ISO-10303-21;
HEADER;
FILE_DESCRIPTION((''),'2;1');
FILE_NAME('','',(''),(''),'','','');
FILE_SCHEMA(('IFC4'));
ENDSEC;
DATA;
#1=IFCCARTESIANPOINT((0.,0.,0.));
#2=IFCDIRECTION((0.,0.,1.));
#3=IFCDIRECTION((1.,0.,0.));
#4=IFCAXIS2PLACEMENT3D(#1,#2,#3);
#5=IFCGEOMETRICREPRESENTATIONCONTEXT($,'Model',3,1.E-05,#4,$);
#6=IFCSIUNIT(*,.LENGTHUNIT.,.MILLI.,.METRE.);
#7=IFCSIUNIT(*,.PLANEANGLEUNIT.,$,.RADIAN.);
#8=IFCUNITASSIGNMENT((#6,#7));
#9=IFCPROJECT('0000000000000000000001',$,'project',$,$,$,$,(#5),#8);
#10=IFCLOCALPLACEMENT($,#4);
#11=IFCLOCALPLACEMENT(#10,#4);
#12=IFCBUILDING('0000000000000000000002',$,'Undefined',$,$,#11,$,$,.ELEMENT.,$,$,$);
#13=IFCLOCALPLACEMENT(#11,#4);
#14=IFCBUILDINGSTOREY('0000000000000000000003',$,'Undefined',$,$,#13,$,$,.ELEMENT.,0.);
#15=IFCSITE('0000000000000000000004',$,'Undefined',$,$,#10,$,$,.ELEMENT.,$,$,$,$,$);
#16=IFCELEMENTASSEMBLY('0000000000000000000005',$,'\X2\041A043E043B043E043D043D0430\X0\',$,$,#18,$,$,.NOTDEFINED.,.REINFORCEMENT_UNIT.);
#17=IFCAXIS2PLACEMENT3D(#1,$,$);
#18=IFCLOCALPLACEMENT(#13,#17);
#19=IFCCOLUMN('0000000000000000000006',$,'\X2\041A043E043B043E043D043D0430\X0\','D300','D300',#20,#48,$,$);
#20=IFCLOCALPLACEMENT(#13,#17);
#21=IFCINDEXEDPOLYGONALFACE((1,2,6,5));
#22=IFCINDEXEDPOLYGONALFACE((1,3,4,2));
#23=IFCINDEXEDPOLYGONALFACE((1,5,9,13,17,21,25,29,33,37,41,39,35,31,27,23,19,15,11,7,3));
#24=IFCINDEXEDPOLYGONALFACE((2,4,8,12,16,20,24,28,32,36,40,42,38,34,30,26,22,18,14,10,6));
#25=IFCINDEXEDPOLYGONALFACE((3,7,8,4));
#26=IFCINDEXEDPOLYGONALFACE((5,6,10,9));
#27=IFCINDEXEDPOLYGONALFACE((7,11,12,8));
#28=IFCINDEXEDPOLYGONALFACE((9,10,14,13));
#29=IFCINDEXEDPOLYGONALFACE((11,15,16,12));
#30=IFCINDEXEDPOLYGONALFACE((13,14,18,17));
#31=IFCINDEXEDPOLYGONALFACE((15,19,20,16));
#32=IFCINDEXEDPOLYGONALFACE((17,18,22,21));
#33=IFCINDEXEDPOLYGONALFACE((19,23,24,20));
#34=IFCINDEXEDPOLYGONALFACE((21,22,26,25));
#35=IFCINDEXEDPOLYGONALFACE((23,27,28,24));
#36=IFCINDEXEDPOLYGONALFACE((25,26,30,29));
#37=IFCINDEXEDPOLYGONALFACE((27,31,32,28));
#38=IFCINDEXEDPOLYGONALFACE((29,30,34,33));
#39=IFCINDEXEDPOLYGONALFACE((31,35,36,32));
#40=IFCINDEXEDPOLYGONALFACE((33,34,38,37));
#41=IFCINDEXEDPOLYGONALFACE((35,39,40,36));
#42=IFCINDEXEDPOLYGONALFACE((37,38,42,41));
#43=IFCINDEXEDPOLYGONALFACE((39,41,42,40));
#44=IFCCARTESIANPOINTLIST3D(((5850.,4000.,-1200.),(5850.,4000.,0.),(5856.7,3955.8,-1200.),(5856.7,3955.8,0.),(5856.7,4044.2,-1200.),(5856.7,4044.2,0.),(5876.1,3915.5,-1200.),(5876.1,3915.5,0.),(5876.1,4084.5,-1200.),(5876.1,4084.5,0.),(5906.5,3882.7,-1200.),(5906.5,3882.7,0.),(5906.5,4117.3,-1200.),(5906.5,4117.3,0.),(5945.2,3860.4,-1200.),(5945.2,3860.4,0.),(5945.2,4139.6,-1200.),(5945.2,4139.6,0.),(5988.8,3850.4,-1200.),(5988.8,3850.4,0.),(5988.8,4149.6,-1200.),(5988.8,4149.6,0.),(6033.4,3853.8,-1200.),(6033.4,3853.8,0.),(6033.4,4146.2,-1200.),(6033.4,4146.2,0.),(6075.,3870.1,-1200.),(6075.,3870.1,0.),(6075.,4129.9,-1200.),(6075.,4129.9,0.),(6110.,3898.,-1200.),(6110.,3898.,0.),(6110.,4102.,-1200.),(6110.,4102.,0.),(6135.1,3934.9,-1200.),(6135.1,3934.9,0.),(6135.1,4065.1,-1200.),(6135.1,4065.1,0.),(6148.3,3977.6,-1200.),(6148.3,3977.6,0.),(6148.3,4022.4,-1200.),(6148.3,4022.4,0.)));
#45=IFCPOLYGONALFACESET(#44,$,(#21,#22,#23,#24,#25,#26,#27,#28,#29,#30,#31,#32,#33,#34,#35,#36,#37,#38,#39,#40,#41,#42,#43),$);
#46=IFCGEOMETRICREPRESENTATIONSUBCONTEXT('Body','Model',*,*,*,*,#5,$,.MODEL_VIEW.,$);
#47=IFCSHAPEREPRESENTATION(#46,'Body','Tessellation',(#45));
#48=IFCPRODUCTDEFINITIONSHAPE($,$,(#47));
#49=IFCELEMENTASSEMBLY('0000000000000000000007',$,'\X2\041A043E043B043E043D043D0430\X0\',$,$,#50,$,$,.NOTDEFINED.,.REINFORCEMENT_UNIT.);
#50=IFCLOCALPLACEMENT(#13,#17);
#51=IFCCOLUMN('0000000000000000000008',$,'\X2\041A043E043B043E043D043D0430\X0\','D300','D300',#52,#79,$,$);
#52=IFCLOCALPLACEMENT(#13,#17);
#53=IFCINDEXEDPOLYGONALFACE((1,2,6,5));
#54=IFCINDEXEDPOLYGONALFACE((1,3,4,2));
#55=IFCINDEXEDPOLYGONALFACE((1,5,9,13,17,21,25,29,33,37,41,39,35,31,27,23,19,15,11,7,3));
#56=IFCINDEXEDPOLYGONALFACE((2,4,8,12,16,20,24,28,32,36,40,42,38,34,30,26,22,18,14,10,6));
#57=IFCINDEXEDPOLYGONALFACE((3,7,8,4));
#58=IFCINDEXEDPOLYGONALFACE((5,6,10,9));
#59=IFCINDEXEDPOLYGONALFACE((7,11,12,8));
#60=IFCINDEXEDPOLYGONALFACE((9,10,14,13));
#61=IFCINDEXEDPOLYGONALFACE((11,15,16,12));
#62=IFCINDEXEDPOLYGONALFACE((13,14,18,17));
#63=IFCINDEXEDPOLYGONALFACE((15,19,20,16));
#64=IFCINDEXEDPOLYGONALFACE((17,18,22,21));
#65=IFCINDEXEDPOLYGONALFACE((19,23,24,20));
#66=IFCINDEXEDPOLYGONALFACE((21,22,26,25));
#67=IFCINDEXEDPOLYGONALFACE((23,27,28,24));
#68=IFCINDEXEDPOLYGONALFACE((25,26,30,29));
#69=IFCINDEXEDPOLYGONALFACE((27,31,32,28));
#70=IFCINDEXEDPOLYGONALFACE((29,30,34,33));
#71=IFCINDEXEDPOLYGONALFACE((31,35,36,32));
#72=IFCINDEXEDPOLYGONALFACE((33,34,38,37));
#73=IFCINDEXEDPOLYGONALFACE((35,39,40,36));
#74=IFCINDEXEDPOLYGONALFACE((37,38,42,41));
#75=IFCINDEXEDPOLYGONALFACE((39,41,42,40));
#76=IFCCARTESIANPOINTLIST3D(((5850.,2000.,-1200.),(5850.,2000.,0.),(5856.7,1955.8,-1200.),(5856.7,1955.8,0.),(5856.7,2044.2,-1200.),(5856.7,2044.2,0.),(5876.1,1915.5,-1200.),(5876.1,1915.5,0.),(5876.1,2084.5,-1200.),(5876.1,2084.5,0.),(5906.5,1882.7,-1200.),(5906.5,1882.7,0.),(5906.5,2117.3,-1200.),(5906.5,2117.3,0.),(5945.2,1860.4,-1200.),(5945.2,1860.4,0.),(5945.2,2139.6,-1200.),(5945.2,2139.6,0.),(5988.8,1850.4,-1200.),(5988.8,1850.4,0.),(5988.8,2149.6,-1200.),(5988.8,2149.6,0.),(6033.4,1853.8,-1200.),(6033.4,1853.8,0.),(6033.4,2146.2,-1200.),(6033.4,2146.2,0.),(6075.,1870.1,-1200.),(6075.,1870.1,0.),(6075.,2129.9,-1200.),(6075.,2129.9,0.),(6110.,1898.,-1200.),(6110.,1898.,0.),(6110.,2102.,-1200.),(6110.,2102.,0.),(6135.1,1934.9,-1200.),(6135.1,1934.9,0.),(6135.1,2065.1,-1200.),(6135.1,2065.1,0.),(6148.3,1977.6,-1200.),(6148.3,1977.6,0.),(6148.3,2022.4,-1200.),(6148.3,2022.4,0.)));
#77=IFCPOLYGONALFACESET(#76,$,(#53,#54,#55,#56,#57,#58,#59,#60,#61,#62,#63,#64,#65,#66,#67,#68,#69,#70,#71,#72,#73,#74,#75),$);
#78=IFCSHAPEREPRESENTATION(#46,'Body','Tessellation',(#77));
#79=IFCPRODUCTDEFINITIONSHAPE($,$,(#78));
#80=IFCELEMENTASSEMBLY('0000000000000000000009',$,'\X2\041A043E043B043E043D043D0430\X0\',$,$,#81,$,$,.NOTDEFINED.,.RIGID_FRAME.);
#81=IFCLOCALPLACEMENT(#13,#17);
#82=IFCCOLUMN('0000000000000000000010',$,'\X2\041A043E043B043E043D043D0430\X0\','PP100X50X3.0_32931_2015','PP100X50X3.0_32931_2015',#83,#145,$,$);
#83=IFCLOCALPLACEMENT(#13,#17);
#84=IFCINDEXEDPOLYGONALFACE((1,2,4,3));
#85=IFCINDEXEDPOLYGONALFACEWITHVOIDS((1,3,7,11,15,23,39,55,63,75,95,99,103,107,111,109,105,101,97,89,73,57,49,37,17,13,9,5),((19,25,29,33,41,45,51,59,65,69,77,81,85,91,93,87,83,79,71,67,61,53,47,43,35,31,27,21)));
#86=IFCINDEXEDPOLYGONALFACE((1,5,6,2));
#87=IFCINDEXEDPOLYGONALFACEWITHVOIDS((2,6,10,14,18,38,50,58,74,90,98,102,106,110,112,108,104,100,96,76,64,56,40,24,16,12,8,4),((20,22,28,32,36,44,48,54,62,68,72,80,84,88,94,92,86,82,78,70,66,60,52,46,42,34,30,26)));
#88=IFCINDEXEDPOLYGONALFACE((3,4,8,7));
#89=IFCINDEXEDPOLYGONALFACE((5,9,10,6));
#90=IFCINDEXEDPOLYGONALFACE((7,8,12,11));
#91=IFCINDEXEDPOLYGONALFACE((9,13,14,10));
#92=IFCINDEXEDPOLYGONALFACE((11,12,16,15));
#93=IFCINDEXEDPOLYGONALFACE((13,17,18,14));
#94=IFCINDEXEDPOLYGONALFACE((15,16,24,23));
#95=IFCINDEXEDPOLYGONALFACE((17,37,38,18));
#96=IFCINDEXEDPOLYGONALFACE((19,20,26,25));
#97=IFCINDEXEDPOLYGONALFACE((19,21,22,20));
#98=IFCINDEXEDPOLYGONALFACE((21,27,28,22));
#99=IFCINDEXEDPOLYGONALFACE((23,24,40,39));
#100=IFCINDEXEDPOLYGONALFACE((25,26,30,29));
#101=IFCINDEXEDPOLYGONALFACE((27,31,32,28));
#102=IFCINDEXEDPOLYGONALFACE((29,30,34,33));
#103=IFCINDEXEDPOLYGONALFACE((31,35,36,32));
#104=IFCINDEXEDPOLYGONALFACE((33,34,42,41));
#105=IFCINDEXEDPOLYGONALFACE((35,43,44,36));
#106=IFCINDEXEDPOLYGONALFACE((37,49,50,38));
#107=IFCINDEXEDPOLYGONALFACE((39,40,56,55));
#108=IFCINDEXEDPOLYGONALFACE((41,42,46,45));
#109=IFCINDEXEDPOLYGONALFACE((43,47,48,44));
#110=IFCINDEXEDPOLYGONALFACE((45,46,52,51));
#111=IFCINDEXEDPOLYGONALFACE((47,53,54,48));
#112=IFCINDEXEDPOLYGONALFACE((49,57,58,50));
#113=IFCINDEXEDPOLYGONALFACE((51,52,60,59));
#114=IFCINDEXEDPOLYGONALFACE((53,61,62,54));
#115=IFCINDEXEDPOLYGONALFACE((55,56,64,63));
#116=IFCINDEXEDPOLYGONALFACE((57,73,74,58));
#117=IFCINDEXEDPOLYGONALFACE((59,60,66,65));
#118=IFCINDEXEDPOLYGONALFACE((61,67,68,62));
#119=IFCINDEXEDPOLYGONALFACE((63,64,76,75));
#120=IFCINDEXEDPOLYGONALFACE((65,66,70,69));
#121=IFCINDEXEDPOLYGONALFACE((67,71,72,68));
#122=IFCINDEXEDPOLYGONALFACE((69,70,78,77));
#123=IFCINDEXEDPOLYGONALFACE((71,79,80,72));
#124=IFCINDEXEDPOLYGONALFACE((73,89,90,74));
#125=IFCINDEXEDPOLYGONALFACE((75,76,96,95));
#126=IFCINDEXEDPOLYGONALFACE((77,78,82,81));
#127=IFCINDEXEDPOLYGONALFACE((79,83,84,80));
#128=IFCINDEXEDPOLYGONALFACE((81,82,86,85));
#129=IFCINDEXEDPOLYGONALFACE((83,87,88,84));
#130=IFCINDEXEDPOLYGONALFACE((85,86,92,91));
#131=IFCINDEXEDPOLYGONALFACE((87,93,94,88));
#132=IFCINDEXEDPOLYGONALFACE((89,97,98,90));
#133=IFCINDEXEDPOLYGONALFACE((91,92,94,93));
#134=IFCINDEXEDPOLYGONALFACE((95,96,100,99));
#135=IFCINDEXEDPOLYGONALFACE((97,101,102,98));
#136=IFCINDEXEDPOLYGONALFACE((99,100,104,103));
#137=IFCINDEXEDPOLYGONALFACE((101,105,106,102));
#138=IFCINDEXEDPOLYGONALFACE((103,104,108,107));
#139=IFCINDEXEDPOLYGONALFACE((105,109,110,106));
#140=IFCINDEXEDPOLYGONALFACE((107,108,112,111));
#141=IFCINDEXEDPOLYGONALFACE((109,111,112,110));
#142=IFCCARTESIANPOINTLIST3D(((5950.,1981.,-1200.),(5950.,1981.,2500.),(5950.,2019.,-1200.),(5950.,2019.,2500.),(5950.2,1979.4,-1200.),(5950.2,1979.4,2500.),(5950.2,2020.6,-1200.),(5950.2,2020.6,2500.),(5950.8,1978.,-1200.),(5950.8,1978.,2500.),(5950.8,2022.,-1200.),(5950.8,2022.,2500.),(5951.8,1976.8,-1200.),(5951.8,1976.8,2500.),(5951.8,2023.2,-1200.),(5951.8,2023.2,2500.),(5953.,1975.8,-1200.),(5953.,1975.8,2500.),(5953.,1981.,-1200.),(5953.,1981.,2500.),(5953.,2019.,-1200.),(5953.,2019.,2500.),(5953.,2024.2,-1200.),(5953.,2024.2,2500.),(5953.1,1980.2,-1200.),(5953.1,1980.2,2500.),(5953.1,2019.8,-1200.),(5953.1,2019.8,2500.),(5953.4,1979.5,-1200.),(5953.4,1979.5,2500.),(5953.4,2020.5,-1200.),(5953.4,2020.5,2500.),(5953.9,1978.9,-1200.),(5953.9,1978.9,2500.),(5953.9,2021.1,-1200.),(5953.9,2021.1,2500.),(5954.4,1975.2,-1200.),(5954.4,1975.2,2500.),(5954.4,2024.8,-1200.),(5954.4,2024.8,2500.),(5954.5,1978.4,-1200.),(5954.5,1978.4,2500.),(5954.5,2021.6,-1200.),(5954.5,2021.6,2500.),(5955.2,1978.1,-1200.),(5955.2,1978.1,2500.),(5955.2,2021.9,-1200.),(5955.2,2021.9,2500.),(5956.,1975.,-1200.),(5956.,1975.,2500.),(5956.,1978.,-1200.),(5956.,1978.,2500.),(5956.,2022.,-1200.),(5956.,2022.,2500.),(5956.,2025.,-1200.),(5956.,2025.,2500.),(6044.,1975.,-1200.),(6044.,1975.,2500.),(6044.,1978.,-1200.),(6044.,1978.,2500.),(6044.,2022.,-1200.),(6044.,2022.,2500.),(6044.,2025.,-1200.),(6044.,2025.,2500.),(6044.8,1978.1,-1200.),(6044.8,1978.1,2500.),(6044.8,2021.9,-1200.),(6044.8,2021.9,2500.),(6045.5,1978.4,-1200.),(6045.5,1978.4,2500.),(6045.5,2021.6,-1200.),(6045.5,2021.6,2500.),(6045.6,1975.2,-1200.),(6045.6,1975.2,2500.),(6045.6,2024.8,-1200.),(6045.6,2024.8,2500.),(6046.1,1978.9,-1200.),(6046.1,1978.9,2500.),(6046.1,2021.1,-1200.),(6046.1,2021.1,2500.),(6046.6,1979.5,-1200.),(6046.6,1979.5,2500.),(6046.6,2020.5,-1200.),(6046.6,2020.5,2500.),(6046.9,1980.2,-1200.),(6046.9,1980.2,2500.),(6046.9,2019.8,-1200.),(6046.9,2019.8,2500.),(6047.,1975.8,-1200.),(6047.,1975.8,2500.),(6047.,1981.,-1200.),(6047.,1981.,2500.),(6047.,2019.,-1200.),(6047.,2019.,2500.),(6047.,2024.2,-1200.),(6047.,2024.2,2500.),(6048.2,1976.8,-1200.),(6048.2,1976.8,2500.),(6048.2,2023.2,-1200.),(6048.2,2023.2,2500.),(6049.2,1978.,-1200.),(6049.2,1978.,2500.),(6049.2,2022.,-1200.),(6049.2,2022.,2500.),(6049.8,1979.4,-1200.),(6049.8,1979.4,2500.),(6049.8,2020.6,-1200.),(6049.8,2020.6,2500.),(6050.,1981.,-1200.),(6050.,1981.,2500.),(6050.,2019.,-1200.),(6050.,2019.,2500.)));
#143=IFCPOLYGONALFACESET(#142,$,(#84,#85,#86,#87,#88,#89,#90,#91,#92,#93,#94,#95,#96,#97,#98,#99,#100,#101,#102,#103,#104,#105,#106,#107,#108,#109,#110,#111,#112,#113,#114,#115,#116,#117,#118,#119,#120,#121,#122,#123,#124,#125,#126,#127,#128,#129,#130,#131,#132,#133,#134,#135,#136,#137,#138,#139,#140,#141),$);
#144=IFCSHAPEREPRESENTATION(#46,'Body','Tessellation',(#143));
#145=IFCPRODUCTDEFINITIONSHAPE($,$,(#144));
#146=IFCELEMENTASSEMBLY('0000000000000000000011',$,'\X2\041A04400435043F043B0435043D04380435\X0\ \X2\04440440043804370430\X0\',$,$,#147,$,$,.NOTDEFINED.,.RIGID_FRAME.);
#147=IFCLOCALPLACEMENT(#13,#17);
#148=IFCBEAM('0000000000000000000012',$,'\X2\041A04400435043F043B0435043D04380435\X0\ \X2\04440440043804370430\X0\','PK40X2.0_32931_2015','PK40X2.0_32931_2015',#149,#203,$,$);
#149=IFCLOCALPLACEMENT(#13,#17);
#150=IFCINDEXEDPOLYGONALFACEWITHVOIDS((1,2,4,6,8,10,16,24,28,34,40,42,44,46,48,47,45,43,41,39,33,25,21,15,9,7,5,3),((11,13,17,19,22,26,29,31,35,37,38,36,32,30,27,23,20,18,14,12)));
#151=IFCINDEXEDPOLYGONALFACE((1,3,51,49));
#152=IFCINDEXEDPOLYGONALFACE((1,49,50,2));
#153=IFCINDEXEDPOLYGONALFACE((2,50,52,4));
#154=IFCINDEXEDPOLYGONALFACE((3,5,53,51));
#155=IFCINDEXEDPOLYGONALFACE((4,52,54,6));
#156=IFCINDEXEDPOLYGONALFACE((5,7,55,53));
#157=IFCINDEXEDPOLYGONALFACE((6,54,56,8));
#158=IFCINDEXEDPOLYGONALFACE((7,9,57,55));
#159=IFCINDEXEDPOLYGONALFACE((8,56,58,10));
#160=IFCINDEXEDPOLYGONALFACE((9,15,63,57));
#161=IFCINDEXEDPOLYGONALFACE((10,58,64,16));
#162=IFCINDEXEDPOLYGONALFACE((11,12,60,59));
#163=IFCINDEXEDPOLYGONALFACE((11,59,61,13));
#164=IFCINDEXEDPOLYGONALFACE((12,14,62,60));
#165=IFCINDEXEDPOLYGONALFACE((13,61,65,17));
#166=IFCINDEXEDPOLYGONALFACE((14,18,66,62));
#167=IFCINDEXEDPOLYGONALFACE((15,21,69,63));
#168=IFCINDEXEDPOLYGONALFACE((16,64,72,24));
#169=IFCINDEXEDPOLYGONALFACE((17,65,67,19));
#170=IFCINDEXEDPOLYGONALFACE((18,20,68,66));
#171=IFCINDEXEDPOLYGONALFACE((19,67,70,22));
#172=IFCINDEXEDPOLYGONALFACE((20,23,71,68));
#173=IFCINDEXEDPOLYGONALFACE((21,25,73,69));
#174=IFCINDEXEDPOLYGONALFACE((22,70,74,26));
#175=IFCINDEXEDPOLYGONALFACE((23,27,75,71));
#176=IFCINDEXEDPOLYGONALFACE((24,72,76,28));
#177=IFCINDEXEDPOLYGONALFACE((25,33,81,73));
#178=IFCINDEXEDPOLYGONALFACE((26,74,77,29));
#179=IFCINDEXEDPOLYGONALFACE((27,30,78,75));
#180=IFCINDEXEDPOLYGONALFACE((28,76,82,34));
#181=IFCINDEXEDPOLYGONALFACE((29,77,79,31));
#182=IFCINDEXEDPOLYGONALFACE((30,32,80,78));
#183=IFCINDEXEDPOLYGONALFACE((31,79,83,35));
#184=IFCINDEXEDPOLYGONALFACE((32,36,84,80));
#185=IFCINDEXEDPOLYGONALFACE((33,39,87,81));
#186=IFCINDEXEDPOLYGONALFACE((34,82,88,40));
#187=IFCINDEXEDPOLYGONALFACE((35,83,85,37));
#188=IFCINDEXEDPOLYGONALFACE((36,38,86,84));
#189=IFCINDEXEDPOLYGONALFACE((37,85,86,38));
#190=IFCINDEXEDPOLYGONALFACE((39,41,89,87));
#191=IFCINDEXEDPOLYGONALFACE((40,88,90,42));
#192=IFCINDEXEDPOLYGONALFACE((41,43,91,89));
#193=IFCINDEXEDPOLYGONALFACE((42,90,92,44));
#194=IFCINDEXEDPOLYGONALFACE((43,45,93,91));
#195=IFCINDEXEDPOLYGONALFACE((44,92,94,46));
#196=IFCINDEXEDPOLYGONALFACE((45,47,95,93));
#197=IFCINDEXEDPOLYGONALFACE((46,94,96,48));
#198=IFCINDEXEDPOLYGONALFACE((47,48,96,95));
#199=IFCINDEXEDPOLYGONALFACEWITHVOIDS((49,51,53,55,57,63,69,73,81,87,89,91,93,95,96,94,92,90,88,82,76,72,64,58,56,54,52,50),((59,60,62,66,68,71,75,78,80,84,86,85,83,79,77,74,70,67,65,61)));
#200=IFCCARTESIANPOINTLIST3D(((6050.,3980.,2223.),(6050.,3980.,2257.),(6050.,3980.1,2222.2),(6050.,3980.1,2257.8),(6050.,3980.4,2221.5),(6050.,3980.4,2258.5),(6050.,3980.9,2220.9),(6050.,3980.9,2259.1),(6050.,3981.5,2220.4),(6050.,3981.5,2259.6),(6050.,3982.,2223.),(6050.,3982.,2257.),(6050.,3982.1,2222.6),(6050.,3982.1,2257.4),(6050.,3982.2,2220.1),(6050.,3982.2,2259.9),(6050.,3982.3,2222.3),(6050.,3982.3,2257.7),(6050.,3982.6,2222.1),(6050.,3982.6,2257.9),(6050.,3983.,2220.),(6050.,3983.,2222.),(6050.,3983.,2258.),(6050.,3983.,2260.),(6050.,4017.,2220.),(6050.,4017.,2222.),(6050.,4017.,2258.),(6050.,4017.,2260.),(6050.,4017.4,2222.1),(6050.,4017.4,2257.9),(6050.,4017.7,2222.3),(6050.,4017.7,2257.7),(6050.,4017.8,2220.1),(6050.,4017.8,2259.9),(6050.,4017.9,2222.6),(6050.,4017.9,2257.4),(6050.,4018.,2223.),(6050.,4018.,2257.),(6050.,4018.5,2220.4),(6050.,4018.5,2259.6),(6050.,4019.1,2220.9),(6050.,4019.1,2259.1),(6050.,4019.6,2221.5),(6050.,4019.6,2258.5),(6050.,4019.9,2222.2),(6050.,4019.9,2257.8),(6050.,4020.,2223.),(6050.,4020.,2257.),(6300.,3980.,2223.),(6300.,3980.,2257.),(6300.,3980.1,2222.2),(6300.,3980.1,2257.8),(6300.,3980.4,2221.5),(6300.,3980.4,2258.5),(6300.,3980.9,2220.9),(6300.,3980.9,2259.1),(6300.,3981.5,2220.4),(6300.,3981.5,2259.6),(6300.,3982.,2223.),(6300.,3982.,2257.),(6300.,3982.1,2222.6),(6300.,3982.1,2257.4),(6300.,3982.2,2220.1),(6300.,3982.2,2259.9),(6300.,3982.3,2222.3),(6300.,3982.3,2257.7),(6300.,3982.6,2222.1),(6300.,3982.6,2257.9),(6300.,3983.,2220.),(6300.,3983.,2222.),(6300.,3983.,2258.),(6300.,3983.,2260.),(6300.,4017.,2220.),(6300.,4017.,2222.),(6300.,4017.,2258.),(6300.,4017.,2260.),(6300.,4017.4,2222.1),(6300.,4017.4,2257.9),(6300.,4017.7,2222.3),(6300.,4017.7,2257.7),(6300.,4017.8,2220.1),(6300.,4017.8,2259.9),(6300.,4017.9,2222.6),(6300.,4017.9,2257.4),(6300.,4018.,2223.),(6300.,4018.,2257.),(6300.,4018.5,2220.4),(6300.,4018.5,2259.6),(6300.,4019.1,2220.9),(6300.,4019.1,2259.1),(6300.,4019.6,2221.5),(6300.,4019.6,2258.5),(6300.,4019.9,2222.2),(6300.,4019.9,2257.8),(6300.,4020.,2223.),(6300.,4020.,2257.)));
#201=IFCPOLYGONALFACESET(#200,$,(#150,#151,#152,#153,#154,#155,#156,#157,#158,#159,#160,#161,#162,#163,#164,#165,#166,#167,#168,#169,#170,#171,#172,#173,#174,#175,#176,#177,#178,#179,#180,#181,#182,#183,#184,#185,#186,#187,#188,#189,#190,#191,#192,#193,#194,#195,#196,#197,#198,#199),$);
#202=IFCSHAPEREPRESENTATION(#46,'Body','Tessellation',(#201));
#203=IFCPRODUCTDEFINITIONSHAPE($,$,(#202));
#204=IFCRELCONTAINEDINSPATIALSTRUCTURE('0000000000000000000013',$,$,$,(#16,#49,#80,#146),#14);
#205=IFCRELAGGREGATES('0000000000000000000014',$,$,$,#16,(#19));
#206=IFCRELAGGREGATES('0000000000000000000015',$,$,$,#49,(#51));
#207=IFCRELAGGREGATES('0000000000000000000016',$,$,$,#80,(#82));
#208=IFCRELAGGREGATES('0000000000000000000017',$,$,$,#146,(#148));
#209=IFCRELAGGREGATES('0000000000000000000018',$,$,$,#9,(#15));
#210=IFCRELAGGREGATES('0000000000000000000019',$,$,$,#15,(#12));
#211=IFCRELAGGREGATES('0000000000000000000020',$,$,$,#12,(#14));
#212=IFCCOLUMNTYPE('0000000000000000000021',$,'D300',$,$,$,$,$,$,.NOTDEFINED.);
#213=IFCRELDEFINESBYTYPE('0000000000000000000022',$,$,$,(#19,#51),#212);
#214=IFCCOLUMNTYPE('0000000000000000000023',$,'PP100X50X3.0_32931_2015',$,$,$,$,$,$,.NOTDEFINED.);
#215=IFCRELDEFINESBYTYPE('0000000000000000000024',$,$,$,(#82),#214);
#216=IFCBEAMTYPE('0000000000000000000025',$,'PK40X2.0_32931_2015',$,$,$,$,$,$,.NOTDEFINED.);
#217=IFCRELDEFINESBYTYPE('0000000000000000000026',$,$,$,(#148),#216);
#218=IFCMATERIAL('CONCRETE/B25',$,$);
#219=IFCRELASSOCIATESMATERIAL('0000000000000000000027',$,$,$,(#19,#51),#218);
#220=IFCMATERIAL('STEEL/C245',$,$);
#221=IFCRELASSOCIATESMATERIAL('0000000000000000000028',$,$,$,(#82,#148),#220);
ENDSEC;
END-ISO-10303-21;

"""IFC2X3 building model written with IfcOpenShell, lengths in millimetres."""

from ifc_helpers import new_model, si_unit, frame, origin_with_axes, origin_2d_with_axis, place, context, subcontext, project, spatial, hollow_rectangle, circle, extrude, material, type_object, element, aggregate, save


model = new_model("IFC2X3")

# Units and contexts
model_context = context("Model", 3, precision=1e-05, world=origin_with_axes())
body_context = subcontext(model_context, "Body", "Model", "MODEL_VIEW")
ifc_project = project(units=[si_unit("LENGTHUNIT", "METRE", prefix="MILLI"), si_unit("PLANEANGLEUNIT", "RADIAN")], contexts=[model_context])

# Site, building, storey
site_placement = place(None, origin_with_axes())
site = spatial("IfcSite", under=ifc_project, at=site_placement, Name="Undefined", CompositionType="ELEMENT")
building_placement = place(site_placement, origin_with_axes())
building = spatial("IfcBuilding", under=site, at=building_placement, Name="Undefined", CompositionType="ELEMENT")
storey_placement = place(building_placement, origin_with_axes())
storey = spatial("IfcBuildingStorey", under=building, at=storey_placement, Name="Undefined", CompositionType="ELEMENT", Elevation=0.0)

# Element assemblies, columns
assembly_1_placement = place(storey_placement, origin_with_axes())
assembly_1 = element("IfcElementAssembly", 1, at=assembly_1_placement, inside=storey, Name="Колонна", AssemblyPlace="NOTDEFINED", PredefinedType="REINFORCEMENT_UNIT")
ifc_material_1 = material(Name="CONCRETE/B25")
column_type_1 = type_object("IfcColumnType", Name="D300", PredefinedType="NOTDEFINED")
column_1_placement = place(assembly_1_placement, frame((6000.0, 4000.0, -1200.0), z_axis=(0.0, 0.0, 1.0), x_axis=(0.0, 1.0, 0.0)))
column_1 = element("IfcColumn", 2, at=column_1_placement, type_object=column_type_1, material=ifc_material_1, Name="Колонна", Description="D300", ObjectType="D300", context=body_context, shape_type="SweptSolid", body=[
    extrude(circle(Radius=150.0, at=origin_2d_with_axis()), frame((0.0, 0.0, 1200.0), z_axis=(0.0, 0.0, -1.0), x_axis=(0.0, 1.0, 0.0)), (0.0, 0.0, 1.0), 1200.0),
])
aggregate(assembly_1, [column_1])
assembly_2_placement = place(storey_placement, origin_with_axes())
assembly_2 = element("IfcElementAssembly", 3, at=assembly_2_placement, inside=storey, Name="Колонна", AssemblyPlace="NOTDEFINED", PredefinedType="REINFORCEMENT_UNIT")
column_2_placement = place(assembly_2_placement, frame((6000.0, 2000.0, -1200.0), z_axis=(0.0, 0.0, 1.0), x_axis=(0.0, 1.0, 0.0)))
column_2 = element("IfcColumn", 4, at=column_2_placement, type_object=column_type_1, material=ifc_material_1, Name="Колонна", Description="D300", ObjectType="D300", context=body_context, shape_type="SweptSolid", body=[
    extrude(circle(Radius=150.0, at=origin_2d_with_axis()), frame((0.0, 0.0, 1200.0), z_axis=(0.0, 0.0, -1.0), x_axis=(0.0, 1.0, 0.0)), (0.0, 0.0, 1.0), 1200.0),
])
aggregate(assembly_2, [column_2])
assembly_3_placement = place(storey_placement, origin_with_axes())
assembly_3 = element("IfcElementAssembly", 5, at=assembly_3_placement, inside=storey, Name="Колонна", AssemblyPlace="NOTDEFINED", PredefinedType="RIGID_FRAME")
ifc_material_2 = material(Name="STEEL/C245")
column_type_2 = type_object("IfcColumnType", Name="PP100X50X3.0_32931_2015", PredefinedType="NOTDEFINED")
column_3_placement = place(assembly_3_placement, frame((6000.0, 2000.0, -1200.0), z_axis=(0.0, 0.0, 1.0), x_axis=(-1.0, 0.0, 0.0)))
column_3 = element("IfcColumn", 6, at=column_3_placement, type_object=column_type_2, material=ifc_material_2, Name="Колонна", Description="PP100X50X3.0_32931_2015", ObjectType="PP100X50X3.0_32931_2015", context=body_context, shape_type="SweptSolid", body=[
    extrude(hollow_rectangle(XDim=50.0, YDim=100.0, WallThickness=3.0, InnerFilletRadius=3.0, OuterFilletRadius=6.0, at=origin_2d_with_axis()), frame((0.0, 0.0, 3700.0), z_axis=(0.0, 0.0, -1.0), x_axis=(0.0, 1.0, 0.0)), (0.0, 0.0, 1.0), 3700.0),
])
aggregate(assembly_3, [column_3])

# Element assembly, beam
assembly_4_placement = place(storey_placement, origin_with_axes())
assembly_4 = element("IfcElementAssembly", 7, at=assembly_4_placement, inside=storey, Name="Крепление фриза", AssemblyPlace="NOTDEFINED", PredefinedType="RIGID_FRAME")
beam_type_1 = type_object("IfcBeamType", Name="PK40X2.0_32931_2015", PredefinedType="NOTDEFINED")
beam_1_placement = place(assembly_4_placement, frame((6300.0, 4000.0, 2240.0), z_axis=(0.0, 0.0, -1.0), x_axis=(-1.0, 0.0, 0.0)))
beam_1 = element("IfcBeam", 8, at=beam_1_placement, type_object=beam_type_1, material=ifc_material_2, Name="Крепление фриза", Description="PK40X2.0_32931_2015", ObjectType="PK40X2.0_32931_2015", context=body_context, shape_type="SweptSolid", body=[
    extrude(hollow_rectangle(XDim=40.0, YDim=40.0, WallThickness=2.0, InnerFilletRadius=1.0, OuterFilletRadius=3.0, at=origin_2d_with_axis()), frame((250.0, 0.0, 0.0), z_axis=(-1.0, 0.0, 0.0), x_axis=(0.0, -1.0, 0.0)), (0.0, 0.0, 1.0), 250.0),
])
aggregate(assembly_4, [beam_1])

save(model, "model.ifc")
